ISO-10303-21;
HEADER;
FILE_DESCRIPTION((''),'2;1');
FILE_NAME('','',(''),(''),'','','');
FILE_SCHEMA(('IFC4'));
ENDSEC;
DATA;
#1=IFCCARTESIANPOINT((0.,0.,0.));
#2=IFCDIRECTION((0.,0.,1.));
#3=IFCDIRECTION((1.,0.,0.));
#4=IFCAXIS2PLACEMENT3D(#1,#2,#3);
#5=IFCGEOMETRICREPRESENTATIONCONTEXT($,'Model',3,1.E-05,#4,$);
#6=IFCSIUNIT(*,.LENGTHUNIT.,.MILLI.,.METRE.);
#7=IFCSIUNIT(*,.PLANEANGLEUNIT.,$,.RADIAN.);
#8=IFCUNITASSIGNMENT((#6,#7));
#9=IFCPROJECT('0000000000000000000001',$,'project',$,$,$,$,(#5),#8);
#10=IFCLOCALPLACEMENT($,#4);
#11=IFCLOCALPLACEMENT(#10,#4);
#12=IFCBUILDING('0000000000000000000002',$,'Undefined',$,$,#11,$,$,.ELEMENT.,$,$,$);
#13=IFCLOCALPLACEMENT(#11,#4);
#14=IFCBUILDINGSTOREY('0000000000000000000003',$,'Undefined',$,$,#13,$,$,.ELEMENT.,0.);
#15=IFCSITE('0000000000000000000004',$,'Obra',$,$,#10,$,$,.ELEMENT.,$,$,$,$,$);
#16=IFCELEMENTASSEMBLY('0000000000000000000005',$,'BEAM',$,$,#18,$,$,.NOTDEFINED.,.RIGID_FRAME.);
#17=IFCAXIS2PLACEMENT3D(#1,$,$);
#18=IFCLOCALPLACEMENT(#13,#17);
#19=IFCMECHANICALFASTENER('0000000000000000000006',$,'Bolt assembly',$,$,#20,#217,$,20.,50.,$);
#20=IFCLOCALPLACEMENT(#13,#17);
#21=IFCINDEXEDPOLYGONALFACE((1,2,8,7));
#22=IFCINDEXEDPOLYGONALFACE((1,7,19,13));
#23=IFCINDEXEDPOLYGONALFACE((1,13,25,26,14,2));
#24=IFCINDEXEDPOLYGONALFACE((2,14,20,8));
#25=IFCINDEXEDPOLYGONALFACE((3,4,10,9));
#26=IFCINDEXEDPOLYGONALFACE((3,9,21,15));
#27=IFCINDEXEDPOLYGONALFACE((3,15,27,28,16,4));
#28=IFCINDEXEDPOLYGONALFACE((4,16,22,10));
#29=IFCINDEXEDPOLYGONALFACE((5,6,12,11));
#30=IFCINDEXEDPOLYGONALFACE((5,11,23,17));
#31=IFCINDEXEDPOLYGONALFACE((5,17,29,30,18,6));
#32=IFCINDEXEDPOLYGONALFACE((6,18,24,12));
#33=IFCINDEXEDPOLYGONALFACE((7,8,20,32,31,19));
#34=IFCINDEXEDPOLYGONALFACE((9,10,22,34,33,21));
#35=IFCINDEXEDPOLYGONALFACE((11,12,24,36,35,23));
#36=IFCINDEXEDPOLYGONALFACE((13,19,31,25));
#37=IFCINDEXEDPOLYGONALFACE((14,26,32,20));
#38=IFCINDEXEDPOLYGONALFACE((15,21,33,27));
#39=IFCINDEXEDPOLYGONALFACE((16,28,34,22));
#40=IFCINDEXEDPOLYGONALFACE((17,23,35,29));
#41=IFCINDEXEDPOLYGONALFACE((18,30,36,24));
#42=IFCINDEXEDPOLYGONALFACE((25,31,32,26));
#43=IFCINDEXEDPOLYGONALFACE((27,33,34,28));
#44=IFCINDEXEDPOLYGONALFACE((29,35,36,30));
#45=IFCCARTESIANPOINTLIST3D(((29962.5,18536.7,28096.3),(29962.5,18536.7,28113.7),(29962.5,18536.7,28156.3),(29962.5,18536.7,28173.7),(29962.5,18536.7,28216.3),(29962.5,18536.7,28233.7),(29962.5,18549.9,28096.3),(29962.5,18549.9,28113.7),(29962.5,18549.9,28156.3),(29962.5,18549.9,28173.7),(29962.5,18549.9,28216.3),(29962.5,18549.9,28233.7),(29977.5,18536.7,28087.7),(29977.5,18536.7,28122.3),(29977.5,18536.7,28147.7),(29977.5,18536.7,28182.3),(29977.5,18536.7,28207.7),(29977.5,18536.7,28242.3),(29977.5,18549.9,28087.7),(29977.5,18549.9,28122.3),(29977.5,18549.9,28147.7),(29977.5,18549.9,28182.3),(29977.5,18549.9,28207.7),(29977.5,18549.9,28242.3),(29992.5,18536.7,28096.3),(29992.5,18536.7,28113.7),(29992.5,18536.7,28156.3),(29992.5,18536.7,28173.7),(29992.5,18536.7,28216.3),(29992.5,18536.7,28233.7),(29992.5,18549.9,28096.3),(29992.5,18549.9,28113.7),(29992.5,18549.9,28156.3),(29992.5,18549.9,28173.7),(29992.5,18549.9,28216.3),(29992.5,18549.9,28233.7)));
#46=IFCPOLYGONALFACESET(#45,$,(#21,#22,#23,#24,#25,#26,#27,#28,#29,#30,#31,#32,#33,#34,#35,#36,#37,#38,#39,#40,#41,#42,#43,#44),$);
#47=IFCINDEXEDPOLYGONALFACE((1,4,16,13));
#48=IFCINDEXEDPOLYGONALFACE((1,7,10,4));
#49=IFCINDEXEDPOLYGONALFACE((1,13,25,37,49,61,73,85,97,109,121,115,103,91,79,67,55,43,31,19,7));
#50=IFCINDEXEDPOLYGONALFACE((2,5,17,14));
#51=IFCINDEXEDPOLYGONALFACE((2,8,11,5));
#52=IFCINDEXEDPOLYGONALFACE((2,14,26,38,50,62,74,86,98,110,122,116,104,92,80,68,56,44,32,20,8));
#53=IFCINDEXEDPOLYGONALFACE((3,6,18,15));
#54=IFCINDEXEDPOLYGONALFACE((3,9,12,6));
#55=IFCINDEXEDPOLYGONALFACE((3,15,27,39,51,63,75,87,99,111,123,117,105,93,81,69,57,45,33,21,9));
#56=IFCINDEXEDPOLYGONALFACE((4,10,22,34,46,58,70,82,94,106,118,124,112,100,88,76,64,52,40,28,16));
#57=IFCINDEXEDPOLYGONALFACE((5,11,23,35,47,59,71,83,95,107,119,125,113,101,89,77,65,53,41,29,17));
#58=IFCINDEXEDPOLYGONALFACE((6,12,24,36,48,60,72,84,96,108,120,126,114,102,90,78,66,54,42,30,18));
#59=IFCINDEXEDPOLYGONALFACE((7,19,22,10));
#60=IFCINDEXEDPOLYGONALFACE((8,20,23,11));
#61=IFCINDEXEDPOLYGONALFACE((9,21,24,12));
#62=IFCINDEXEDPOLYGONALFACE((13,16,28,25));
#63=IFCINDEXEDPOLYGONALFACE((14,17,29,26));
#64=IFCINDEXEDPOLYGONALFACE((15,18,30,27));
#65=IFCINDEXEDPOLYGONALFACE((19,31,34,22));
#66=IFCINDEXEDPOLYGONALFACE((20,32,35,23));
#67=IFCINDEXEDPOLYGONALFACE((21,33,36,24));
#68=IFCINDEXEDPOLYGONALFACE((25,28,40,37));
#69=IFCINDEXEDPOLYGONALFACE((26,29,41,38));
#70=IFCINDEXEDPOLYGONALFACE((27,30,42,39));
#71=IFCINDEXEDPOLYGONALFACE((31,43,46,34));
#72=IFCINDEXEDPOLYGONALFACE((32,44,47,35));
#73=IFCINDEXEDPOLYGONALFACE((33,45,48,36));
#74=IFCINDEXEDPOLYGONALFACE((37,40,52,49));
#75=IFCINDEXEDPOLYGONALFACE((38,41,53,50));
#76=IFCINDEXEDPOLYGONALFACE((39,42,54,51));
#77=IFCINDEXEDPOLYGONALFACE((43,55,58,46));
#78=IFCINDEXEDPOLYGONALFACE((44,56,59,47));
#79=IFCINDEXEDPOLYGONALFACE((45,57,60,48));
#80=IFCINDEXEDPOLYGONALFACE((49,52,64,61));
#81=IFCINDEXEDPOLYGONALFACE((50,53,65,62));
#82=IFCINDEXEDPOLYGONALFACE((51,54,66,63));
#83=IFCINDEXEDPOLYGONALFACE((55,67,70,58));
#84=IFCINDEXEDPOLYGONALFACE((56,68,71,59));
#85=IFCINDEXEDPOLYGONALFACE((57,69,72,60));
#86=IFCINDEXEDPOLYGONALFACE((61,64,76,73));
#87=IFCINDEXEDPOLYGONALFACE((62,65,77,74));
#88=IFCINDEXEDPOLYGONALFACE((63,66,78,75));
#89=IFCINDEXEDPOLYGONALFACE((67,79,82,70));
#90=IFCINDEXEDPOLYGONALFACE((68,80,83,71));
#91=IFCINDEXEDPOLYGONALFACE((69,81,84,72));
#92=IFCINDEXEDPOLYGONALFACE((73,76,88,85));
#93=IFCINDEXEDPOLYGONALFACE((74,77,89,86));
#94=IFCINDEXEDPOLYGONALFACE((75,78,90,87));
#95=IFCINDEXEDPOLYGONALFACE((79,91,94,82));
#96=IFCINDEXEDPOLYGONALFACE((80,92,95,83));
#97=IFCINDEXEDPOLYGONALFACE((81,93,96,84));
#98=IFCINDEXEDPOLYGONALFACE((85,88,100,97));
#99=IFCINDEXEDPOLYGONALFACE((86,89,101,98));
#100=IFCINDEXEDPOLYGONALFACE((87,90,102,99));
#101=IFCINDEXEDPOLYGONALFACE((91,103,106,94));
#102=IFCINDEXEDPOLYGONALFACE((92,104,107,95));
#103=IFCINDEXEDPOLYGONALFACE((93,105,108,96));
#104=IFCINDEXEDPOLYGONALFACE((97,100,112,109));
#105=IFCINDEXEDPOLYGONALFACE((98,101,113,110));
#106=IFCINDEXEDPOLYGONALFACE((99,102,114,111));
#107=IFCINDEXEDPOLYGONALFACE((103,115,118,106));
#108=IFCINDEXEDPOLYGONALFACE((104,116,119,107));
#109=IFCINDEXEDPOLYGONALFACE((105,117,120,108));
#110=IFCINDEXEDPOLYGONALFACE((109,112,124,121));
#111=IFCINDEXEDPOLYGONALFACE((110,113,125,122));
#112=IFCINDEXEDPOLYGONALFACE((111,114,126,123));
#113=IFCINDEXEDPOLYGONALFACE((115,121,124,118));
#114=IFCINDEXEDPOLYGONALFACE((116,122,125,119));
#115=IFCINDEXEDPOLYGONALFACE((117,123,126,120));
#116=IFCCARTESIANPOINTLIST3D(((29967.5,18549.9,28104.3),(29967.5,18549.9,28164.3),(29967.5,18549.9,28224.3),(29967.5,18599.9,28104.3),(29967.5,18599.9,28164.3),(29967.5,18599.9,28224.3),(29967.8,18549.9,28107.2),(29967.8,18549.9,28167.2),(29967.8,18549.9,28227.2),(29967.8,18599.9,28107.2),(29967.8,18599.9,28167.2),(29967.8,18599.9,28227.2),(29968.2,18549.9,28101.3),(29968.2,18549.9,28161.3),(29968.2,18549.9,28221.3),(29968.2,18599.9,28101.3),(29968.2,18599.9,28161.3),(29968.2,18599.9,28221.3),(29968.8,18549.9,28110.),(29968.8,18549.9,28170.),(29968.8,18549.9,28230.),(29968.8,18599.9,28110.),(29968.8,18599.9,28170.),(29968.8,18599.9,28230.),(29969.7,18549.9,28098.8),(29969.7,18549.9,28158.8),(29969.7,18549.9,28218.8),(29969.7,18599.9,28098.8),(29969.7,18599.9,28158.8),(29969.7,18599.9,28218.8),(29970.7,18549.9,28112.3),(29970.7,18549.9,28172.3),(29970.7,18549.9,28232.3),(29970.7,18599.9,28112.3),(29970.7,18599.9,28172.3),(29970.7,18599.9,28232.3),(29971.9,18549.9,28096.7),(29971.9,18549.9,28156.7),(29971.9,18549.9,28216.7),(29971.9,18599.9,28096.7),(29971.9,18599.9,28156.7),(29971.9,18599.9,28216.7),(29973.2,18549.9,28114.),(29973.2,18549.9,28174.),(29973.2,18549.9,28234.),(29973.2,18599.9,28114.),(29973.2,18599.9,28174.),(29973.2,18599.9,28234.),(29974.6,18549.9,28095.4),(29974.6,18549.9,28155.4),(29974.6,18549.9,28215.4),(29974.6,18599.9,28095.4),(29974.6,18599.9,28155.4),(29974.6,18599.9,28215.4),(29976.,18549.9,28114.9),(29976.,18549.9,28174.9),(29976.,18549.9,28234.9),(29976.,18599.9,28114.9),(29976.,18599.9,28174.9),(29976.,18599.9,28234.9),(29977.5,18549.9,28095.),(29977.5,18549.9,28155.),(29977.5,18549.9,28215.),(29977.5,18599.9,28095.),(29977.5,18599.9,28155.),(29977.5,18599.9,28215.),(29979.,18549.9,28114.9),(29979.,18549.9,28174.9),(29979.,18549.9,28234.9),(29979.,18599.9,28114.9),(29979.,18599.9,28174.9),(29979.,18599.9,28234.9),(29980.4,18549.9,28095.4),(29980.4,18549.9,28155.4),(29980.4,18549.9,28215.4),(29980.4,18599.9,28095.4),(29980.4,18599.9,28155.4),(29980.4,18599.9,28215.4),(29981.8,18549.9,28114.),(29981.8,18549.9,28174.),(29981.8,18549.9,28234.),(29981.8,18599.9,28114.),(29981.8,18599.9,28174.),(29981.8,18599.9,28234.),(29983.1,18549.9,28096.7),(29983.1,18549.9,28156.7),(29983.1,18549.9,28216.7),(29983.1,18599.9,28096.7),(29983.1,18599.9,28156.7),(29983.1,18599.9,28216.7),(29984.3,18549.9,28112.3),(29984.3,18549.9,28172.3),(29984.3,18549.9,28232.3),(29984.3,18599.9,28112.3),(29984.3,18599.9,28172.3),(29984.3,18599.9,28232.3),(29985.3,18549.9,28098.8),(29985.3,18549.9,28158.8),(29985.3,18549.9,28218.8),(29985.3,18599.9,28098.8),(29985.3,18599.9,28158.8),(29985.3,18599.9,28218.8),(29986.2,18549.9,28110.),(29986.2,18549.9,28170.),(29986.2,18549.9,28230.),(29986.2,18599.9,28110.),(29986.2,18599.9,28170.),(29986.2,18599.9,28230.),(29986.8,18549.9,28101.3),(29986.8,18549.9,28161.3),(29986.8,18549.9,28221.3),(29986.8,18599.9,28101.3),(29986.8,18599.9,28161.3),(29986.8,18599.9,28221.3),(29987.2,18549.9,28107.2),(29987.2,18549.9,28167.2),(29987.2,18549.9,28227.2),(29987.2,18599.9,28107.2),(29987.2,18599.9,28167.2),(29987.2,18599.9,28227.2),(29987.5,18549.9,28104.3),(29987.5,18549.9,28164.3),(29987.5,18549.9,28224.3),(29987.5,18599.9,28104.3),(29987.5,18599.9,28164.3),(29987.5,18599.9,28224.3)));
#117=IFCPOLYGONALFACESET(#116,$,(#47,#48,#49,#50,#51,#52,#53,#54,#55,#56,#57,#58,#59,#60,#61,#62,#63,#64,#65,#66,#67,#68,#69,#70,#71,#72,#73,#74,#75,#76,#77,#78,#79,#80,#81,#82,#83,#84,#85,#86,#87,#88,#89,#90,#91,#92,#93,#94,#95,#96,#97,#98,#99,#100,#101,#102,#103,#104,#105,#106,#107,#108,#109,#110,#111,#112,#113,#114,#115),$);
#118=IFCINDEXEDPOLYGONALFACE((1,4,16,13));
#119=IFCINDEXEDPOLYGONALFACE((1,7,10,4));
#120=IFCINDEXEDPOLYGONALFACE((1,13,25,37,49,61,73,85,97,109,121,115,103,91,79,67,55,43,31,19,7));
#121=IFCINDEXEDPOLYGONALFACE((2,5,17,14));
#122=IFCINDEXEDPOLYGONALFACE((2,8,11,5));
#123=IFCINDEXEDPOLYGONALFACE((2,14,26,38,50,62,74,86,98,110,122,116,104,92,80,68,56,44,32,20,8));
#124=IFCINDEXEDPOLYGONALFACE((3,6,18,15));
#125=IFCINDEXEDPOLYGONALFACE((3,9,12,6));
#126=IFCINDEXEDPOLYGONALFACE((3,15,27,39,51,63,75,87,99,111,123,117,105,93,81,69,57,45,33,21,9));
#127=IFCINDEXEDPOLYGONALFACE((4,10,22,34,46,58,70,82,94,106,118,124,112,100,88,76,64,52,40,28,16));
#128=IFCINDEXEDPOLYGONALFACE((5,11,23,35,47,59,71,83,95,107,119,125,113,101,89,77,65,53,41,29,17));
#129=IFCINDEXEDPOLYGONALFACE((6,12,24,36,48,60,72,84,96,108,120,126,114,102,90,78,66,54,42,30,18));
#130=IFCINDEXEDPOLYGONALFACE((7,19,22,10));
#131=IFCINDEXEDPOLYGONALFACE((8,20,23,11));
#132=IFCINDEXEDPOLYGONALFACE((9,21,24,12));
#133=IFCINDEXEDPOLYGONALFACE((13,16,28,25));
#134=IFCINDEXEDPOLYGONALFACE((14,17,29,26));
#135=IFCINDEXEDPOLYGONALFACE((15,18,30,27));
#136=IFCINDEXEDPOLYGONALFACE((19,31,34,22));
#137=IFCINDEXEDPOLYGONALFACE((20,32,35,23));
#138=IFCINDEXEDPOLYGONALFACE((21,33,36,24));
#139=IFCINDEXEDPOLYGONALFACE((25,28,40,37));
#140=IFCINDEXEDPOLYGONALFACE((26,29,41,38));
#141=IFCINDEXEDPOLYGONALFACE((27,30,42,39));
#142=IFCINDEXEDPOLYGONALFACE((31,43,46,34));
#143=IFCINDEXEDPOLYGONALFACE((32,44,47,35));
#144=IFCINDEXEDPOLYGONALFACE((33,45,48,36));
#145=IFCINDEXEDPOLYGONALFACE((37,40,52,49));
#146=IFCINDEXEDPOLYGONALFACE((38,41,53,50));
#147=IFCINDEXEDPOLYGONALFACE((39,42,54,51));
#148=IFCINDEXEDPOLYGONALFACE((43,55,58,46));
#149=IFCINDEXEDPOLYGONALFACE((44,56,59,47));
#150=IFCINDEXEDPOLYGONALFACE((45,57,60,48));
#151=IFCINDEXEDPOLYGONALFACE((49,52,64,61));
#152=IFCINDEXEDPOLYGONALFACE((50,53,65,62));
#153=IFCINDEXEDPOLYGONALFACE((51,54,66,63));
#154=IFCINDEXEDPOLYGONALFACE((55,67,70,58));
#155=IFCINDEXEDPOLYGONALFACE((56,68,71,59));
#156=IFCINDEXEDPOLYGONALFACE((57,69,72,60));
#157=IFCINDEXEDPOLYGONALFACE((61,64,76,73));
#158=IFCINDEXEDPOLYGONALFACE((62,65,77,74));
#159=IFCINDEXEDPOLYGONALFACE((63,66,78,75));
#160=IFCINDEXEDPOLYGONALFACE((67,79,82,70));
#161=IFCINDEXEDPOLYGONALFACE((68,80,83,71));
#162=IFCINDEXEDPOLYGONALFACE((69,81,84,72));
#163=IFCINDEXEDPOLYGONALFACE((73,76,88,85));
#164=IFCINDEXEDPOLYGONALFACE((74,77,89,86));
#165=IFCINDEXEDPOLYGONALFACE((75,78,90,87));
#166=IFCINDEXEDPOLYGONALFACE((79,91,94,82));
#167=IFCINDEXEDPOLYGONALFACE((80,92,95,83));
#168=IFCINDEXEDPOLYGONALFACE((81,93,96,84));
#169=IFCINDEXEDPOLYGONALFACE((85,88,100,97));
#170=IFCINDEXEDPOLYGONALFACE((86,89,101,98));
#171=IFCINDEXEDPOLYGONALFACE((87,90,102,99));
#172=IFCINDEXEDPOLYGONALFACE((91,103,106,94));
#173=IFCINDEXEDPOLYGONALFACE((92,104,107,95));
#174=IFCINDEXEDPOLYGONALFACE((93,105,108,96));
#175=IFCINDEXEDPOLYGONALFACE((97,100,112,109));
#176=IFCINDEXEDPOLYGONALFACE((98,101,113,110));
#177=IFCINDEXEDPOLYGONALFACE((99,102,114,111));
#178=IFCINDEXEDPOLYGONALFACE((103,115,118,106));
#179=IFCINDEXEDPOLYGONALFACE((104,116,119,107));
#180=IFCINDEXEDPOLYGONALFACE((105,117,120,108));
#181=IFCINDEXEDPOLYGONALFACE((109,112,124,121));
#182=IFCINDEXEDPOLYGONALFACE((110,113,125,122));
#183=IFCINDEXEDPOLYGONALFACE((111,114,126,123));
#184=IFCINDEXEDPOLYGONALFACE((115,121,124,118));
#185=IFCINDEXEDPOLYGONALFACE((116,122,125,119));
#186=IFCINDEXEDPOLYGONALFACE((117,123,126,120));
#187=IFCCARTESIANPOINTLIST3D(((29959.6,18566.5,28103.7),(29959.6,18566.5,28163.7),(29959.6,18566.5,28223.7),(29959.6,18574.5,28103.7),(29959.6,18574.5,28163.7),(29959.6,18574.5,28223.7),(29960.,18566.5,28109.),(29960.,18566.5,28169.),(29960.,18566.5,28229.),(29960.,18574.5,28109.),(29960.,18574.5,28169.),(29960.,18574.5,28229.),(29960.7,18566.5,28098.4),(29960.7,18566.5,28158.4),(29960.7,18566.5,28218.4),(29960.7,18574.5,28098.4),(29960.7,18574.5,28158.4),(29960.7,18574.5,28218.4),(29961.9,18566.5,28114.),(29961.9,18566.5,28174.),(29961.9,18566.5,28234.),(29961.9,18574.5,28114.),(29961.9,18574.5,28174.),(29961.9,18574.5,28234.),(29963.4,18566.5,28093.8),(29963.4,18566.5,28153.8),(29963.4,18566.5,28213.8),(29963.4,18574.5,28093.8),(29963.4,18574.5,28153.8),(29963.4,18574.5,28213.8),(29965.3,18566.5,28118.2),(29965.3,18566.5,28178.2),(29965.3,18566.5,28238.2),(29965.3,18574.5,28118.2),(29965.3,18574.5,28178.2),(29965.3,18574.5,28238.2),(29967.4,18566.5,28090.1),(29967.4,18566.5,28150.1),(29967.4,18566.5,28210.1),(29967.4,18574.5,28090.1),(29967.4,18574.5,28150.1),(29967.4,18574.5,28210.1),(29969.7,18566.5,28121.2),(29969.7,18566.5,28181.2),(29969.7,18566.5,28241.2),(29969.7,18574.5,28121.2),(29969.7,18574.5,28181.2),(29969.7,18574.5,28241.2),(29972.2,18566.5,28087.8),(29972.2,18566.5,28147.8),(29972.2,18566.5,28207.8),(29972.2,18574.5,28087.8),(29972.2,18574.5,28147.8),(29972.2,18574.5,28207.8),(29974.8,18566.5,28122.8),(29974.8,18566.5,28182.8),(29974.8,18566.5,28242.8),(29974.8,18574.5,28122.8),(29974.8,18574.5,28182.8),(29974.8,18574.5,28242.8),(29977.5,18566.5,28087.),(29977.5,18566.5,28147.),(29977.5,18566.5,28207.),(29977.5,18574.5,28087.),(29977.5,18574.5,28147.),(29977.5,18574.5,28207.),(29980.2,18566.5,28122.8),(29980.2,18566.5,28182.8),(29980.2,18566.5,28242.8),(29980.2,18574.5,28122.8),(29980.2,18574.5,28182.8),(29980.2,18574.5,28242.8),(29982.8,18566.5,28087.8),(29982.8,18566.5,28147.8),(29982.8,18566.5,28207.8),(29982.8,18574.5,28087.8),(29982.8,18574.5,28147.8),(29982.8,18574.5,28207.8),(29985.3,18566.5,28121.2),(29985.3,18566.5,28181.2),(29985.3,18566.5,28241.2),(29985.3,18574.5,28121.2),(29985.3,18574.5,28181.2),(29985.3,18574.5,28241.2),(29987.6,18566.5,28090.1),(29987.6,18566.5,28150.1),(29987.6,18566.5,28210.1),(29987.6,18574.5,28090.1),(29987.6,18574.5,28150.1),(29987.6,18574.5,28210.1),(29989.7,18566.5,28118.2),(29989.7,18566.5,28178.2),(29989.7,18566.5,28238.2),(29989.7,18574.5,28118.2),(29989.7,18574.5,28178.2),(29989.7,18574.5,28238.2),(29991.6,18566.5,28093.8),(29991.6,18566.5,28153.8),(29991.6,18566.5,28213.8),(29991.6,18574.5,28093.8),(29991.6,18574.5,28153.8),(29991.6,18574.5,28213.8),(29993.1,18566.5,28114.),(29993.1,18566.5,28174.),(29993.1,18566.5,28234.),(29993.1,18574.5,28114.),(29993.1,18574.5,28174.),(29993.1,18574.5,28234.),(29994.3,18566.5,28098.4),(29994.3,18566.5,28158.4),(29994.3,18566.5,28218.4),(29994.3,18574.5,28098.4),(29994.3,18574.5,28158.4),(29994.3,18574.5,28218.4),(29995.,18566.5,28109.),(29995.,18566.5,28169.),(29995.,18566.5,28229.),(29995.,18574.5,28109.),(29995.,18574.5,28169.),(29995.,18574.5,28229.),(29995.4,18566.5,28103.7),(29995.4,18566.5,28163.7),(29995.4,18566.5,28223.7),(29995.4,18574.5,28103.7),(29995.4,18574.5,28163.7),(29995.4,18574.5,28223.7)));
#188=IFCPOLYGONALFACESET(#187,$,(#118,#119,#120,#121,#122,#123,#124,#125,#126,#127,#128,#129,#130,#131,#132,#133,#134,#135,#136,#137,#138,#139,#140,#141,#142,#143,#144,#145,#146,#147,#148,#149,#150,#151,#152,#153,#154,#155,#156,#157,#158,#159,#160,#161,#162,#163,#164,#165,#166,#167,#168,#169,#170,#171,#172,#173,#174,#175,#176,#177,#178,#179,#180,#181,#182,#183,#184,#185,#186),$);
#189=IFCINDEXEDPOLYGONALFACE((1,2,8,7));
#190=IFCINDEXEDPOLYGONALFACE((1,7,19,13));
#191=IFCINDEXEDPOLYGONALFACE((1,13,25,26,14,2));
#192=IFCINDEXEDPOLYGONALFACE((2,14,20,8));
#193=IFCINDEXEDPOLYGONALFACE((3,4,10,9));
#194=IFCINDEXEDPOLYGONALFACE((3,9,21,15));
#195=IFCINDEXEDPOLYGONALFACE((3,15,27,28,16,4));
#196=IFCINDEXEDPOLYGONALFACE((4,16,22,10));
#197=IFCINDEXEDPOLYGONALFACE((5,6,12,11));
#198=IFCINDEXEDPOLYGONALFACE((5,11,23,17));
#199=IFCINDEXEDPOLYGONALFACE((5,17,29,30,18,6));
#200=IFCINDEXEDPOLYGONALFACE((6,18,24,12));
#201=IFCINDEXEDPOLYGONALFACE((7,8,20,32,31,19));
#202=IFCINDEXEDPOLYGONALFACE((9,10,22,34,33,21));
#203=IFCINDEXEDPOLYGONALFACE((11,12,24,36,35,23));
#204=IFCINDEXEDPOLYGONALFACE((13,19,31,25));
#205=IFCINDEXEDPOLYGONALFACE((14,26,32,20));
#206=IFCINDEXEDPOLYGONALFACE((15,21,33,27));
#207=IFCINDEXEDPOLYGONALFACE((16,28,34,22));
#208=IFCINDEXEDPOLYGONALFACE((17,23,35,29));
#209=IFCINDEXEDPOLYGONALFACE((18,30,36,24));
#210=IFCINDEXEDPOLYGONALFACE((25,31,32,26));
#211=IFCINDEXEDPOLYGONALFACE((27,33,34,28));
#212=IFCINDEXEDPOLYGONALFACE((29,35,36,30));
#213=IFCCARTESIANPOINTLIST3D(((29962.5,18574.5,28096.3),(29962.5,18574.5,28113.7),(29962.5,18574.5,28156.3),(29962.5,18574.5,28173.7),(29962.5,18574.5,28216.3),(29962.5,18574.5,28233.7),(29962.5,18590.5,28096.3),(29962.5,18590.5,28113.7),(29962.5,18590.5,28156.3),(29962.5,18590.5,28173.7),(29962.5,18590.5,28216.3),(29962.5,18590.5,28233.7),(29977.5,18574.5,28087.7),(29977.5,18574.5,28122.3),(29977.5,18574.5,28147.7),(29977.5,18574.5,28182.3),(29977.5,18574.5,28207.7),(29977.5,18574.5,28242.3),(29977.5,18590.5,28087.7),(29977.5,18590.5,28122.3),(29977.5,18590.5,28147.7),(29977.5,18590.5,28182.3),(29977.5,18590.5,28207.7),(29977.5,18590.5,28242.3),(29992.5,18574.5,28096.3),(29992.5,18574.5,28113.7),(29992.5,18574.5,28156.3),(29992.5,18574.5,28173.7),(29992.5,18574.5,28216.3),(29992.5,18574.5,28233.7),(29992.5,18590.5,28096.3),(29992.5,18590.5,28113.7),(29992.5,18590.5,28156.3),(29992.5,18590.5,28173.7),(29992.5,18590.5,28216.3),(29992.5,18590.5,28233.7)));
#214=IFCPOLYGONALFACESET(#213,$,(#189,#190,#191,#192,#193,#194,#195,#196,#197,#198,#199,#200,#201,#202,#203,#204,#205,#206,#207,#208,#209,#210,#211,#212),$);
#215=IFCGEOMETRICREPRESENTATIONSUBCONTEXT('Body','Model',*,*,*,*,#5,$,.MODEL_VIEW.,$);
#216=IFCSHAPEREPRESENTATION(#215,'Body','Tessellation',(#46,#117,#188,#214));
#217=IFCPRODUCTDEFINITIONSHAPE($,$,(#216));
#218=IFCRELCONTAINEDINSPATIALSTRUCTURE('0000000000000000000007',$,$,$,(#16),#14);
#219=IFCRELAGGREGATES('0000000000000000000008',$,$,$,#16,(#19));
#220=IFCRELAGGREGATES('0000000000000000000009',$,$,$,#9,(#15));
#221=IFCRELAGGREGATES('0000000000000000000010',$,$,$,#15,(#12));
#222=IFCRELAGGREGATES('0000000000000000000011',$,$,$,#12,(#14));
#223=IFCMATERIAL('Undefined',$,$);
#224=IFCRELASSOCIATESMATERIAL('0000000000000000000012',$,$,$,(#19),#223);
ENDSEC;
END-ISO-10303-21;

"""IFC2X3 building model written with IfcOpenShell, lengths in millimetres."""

from ifc_helpers import new_model, si_unit, frame, origin_with_axes, origin_2d_with_axis, place, context, subcontext, project, spatial, polyline, circle, outline, extrude, source, transform, mapped, material, element, aggregate, save


model = new_model("IFC2X3")

# Units and contexts
model_context = context("Model", 3, precision=1e-05, world=origin_with_axes())
body_context = subcontext(model_context, "Body", "Model", "MODEL_VIEW")
ifc_project = project(units=[si_unit("LENGTHUNIT", "METRE", prefix="MILLI"), si_unit("PLANEANGLEUNIT", "RADIAN")], contexts=[model_context])

# Site, building, storey
site_placement = place(None, origin_with_axes())
site = spatial("IfcSite", under=ifc_project, at=site_placement, Name="Obra", CompositionType="ELEMENT")
building_placement = place(site_placement, origin_with_axes())
building = spatial("IfcBuilding", under=site, at=building_placement, Name="Undefined", CompositionType="ELEMENT")
storey_placement = place(building_placement, origin_with_axes())
storey = spatial("IfcBuildingStorey", under=building, at=storey_placement, Name="Undefined", CompositionType="ELEMENT", Elevation=0.0)

# Element assembly
assembly_1_placement = place(storey_placement, origin_with_axes())
assembly_1 = element("IfcElementAssembly", 1, at=assembly_1_placement, inside=storey, Name="BEAM", AssemblyPlace="NOTDEFINED", PredefinedType="RIGID_FRAME")

# Shared definitions
ifc_material_1 = material(Name="Undefined")
shared_shape_1 = source(origin_with_axes(), body_context, "Body", "SweptSolid", [
    extrude(outline(polyline([(17.3, 0.0), (8.7, 15.0), (-8.7, 15.0), (-17.3, 0.0), (-8.7, -15.0), (8.7, -15.0), (17.3, 0.0)])), frame((0.0, -26.5, 0.0), z_axis=(0.0, 1.0, 0.0), x_axis=(1.0, 0.0, 0.0)), (0.0, 0.0, 1.0), 13.2),
    extrude(circle(Radius=10.0, at=origin_2d_with_axis()), frame((0.0, -13.3, 0.0), z_axis=(0.0, 1.0, 0.0), x_axis=(1.0, 0.0, 0.0)), (0.0, 0.0, 1.0), 50.0),
    extrude(circle(Radius=18.0, at=origin_2d_with_axis()), frame((0.0, 3.3, 0.0), z_axis=(0.0, 1.0, 0.0), x_axis=(1.0, 0.0, 0.0)), (0.0, 0.0, 1.0), 8.0),
    extrude(outline(polyline([(17.3, 0.0), (8.7, 15.0), (-8.7, 15.0), (-17.3, 0.0), (-8.7, -15.0), (8.7, -15.0), (17.3, 0.0)])), frame((0.0, 11.3, 0.0), z_axis=(0.0, 1.0, 0.0), x_axis=(1.0, 0.0, 0.0)), (0.0, 0.0, 1.0), 16.0),
])

# Mechanical fastener
mechanical_fastener_1_placement = place(assembly_1_placement, frame((29927.5, 18563.2, 28265.0), z_axis=(1.0, 0.0, 0.0), x_axis=(0.0, 0.0, -1.0)))
mechanical_fastener_1 = element("IfcMechanicalFastener", 2, at=mechanical_fastener_1_placement, material=ifc_material_1, Name="Bolt assembly", NominalDiameter=20.0, NominalLength=50.0, context=body_context, shape_type="MappedRepresentation", body=[
    mapped(shared_shape_1, transform((40.0, 0.0, 50.0))),
    mapped(shared_shape_1, transform((100.0, 0.0, 50.0))),
    mapped(shared_shape_1, transform((160.0, 0.0, 50.0))),
])
aggregate(assembly_1, [mechanical_fastener_1])

save(model, "model.ifc")
